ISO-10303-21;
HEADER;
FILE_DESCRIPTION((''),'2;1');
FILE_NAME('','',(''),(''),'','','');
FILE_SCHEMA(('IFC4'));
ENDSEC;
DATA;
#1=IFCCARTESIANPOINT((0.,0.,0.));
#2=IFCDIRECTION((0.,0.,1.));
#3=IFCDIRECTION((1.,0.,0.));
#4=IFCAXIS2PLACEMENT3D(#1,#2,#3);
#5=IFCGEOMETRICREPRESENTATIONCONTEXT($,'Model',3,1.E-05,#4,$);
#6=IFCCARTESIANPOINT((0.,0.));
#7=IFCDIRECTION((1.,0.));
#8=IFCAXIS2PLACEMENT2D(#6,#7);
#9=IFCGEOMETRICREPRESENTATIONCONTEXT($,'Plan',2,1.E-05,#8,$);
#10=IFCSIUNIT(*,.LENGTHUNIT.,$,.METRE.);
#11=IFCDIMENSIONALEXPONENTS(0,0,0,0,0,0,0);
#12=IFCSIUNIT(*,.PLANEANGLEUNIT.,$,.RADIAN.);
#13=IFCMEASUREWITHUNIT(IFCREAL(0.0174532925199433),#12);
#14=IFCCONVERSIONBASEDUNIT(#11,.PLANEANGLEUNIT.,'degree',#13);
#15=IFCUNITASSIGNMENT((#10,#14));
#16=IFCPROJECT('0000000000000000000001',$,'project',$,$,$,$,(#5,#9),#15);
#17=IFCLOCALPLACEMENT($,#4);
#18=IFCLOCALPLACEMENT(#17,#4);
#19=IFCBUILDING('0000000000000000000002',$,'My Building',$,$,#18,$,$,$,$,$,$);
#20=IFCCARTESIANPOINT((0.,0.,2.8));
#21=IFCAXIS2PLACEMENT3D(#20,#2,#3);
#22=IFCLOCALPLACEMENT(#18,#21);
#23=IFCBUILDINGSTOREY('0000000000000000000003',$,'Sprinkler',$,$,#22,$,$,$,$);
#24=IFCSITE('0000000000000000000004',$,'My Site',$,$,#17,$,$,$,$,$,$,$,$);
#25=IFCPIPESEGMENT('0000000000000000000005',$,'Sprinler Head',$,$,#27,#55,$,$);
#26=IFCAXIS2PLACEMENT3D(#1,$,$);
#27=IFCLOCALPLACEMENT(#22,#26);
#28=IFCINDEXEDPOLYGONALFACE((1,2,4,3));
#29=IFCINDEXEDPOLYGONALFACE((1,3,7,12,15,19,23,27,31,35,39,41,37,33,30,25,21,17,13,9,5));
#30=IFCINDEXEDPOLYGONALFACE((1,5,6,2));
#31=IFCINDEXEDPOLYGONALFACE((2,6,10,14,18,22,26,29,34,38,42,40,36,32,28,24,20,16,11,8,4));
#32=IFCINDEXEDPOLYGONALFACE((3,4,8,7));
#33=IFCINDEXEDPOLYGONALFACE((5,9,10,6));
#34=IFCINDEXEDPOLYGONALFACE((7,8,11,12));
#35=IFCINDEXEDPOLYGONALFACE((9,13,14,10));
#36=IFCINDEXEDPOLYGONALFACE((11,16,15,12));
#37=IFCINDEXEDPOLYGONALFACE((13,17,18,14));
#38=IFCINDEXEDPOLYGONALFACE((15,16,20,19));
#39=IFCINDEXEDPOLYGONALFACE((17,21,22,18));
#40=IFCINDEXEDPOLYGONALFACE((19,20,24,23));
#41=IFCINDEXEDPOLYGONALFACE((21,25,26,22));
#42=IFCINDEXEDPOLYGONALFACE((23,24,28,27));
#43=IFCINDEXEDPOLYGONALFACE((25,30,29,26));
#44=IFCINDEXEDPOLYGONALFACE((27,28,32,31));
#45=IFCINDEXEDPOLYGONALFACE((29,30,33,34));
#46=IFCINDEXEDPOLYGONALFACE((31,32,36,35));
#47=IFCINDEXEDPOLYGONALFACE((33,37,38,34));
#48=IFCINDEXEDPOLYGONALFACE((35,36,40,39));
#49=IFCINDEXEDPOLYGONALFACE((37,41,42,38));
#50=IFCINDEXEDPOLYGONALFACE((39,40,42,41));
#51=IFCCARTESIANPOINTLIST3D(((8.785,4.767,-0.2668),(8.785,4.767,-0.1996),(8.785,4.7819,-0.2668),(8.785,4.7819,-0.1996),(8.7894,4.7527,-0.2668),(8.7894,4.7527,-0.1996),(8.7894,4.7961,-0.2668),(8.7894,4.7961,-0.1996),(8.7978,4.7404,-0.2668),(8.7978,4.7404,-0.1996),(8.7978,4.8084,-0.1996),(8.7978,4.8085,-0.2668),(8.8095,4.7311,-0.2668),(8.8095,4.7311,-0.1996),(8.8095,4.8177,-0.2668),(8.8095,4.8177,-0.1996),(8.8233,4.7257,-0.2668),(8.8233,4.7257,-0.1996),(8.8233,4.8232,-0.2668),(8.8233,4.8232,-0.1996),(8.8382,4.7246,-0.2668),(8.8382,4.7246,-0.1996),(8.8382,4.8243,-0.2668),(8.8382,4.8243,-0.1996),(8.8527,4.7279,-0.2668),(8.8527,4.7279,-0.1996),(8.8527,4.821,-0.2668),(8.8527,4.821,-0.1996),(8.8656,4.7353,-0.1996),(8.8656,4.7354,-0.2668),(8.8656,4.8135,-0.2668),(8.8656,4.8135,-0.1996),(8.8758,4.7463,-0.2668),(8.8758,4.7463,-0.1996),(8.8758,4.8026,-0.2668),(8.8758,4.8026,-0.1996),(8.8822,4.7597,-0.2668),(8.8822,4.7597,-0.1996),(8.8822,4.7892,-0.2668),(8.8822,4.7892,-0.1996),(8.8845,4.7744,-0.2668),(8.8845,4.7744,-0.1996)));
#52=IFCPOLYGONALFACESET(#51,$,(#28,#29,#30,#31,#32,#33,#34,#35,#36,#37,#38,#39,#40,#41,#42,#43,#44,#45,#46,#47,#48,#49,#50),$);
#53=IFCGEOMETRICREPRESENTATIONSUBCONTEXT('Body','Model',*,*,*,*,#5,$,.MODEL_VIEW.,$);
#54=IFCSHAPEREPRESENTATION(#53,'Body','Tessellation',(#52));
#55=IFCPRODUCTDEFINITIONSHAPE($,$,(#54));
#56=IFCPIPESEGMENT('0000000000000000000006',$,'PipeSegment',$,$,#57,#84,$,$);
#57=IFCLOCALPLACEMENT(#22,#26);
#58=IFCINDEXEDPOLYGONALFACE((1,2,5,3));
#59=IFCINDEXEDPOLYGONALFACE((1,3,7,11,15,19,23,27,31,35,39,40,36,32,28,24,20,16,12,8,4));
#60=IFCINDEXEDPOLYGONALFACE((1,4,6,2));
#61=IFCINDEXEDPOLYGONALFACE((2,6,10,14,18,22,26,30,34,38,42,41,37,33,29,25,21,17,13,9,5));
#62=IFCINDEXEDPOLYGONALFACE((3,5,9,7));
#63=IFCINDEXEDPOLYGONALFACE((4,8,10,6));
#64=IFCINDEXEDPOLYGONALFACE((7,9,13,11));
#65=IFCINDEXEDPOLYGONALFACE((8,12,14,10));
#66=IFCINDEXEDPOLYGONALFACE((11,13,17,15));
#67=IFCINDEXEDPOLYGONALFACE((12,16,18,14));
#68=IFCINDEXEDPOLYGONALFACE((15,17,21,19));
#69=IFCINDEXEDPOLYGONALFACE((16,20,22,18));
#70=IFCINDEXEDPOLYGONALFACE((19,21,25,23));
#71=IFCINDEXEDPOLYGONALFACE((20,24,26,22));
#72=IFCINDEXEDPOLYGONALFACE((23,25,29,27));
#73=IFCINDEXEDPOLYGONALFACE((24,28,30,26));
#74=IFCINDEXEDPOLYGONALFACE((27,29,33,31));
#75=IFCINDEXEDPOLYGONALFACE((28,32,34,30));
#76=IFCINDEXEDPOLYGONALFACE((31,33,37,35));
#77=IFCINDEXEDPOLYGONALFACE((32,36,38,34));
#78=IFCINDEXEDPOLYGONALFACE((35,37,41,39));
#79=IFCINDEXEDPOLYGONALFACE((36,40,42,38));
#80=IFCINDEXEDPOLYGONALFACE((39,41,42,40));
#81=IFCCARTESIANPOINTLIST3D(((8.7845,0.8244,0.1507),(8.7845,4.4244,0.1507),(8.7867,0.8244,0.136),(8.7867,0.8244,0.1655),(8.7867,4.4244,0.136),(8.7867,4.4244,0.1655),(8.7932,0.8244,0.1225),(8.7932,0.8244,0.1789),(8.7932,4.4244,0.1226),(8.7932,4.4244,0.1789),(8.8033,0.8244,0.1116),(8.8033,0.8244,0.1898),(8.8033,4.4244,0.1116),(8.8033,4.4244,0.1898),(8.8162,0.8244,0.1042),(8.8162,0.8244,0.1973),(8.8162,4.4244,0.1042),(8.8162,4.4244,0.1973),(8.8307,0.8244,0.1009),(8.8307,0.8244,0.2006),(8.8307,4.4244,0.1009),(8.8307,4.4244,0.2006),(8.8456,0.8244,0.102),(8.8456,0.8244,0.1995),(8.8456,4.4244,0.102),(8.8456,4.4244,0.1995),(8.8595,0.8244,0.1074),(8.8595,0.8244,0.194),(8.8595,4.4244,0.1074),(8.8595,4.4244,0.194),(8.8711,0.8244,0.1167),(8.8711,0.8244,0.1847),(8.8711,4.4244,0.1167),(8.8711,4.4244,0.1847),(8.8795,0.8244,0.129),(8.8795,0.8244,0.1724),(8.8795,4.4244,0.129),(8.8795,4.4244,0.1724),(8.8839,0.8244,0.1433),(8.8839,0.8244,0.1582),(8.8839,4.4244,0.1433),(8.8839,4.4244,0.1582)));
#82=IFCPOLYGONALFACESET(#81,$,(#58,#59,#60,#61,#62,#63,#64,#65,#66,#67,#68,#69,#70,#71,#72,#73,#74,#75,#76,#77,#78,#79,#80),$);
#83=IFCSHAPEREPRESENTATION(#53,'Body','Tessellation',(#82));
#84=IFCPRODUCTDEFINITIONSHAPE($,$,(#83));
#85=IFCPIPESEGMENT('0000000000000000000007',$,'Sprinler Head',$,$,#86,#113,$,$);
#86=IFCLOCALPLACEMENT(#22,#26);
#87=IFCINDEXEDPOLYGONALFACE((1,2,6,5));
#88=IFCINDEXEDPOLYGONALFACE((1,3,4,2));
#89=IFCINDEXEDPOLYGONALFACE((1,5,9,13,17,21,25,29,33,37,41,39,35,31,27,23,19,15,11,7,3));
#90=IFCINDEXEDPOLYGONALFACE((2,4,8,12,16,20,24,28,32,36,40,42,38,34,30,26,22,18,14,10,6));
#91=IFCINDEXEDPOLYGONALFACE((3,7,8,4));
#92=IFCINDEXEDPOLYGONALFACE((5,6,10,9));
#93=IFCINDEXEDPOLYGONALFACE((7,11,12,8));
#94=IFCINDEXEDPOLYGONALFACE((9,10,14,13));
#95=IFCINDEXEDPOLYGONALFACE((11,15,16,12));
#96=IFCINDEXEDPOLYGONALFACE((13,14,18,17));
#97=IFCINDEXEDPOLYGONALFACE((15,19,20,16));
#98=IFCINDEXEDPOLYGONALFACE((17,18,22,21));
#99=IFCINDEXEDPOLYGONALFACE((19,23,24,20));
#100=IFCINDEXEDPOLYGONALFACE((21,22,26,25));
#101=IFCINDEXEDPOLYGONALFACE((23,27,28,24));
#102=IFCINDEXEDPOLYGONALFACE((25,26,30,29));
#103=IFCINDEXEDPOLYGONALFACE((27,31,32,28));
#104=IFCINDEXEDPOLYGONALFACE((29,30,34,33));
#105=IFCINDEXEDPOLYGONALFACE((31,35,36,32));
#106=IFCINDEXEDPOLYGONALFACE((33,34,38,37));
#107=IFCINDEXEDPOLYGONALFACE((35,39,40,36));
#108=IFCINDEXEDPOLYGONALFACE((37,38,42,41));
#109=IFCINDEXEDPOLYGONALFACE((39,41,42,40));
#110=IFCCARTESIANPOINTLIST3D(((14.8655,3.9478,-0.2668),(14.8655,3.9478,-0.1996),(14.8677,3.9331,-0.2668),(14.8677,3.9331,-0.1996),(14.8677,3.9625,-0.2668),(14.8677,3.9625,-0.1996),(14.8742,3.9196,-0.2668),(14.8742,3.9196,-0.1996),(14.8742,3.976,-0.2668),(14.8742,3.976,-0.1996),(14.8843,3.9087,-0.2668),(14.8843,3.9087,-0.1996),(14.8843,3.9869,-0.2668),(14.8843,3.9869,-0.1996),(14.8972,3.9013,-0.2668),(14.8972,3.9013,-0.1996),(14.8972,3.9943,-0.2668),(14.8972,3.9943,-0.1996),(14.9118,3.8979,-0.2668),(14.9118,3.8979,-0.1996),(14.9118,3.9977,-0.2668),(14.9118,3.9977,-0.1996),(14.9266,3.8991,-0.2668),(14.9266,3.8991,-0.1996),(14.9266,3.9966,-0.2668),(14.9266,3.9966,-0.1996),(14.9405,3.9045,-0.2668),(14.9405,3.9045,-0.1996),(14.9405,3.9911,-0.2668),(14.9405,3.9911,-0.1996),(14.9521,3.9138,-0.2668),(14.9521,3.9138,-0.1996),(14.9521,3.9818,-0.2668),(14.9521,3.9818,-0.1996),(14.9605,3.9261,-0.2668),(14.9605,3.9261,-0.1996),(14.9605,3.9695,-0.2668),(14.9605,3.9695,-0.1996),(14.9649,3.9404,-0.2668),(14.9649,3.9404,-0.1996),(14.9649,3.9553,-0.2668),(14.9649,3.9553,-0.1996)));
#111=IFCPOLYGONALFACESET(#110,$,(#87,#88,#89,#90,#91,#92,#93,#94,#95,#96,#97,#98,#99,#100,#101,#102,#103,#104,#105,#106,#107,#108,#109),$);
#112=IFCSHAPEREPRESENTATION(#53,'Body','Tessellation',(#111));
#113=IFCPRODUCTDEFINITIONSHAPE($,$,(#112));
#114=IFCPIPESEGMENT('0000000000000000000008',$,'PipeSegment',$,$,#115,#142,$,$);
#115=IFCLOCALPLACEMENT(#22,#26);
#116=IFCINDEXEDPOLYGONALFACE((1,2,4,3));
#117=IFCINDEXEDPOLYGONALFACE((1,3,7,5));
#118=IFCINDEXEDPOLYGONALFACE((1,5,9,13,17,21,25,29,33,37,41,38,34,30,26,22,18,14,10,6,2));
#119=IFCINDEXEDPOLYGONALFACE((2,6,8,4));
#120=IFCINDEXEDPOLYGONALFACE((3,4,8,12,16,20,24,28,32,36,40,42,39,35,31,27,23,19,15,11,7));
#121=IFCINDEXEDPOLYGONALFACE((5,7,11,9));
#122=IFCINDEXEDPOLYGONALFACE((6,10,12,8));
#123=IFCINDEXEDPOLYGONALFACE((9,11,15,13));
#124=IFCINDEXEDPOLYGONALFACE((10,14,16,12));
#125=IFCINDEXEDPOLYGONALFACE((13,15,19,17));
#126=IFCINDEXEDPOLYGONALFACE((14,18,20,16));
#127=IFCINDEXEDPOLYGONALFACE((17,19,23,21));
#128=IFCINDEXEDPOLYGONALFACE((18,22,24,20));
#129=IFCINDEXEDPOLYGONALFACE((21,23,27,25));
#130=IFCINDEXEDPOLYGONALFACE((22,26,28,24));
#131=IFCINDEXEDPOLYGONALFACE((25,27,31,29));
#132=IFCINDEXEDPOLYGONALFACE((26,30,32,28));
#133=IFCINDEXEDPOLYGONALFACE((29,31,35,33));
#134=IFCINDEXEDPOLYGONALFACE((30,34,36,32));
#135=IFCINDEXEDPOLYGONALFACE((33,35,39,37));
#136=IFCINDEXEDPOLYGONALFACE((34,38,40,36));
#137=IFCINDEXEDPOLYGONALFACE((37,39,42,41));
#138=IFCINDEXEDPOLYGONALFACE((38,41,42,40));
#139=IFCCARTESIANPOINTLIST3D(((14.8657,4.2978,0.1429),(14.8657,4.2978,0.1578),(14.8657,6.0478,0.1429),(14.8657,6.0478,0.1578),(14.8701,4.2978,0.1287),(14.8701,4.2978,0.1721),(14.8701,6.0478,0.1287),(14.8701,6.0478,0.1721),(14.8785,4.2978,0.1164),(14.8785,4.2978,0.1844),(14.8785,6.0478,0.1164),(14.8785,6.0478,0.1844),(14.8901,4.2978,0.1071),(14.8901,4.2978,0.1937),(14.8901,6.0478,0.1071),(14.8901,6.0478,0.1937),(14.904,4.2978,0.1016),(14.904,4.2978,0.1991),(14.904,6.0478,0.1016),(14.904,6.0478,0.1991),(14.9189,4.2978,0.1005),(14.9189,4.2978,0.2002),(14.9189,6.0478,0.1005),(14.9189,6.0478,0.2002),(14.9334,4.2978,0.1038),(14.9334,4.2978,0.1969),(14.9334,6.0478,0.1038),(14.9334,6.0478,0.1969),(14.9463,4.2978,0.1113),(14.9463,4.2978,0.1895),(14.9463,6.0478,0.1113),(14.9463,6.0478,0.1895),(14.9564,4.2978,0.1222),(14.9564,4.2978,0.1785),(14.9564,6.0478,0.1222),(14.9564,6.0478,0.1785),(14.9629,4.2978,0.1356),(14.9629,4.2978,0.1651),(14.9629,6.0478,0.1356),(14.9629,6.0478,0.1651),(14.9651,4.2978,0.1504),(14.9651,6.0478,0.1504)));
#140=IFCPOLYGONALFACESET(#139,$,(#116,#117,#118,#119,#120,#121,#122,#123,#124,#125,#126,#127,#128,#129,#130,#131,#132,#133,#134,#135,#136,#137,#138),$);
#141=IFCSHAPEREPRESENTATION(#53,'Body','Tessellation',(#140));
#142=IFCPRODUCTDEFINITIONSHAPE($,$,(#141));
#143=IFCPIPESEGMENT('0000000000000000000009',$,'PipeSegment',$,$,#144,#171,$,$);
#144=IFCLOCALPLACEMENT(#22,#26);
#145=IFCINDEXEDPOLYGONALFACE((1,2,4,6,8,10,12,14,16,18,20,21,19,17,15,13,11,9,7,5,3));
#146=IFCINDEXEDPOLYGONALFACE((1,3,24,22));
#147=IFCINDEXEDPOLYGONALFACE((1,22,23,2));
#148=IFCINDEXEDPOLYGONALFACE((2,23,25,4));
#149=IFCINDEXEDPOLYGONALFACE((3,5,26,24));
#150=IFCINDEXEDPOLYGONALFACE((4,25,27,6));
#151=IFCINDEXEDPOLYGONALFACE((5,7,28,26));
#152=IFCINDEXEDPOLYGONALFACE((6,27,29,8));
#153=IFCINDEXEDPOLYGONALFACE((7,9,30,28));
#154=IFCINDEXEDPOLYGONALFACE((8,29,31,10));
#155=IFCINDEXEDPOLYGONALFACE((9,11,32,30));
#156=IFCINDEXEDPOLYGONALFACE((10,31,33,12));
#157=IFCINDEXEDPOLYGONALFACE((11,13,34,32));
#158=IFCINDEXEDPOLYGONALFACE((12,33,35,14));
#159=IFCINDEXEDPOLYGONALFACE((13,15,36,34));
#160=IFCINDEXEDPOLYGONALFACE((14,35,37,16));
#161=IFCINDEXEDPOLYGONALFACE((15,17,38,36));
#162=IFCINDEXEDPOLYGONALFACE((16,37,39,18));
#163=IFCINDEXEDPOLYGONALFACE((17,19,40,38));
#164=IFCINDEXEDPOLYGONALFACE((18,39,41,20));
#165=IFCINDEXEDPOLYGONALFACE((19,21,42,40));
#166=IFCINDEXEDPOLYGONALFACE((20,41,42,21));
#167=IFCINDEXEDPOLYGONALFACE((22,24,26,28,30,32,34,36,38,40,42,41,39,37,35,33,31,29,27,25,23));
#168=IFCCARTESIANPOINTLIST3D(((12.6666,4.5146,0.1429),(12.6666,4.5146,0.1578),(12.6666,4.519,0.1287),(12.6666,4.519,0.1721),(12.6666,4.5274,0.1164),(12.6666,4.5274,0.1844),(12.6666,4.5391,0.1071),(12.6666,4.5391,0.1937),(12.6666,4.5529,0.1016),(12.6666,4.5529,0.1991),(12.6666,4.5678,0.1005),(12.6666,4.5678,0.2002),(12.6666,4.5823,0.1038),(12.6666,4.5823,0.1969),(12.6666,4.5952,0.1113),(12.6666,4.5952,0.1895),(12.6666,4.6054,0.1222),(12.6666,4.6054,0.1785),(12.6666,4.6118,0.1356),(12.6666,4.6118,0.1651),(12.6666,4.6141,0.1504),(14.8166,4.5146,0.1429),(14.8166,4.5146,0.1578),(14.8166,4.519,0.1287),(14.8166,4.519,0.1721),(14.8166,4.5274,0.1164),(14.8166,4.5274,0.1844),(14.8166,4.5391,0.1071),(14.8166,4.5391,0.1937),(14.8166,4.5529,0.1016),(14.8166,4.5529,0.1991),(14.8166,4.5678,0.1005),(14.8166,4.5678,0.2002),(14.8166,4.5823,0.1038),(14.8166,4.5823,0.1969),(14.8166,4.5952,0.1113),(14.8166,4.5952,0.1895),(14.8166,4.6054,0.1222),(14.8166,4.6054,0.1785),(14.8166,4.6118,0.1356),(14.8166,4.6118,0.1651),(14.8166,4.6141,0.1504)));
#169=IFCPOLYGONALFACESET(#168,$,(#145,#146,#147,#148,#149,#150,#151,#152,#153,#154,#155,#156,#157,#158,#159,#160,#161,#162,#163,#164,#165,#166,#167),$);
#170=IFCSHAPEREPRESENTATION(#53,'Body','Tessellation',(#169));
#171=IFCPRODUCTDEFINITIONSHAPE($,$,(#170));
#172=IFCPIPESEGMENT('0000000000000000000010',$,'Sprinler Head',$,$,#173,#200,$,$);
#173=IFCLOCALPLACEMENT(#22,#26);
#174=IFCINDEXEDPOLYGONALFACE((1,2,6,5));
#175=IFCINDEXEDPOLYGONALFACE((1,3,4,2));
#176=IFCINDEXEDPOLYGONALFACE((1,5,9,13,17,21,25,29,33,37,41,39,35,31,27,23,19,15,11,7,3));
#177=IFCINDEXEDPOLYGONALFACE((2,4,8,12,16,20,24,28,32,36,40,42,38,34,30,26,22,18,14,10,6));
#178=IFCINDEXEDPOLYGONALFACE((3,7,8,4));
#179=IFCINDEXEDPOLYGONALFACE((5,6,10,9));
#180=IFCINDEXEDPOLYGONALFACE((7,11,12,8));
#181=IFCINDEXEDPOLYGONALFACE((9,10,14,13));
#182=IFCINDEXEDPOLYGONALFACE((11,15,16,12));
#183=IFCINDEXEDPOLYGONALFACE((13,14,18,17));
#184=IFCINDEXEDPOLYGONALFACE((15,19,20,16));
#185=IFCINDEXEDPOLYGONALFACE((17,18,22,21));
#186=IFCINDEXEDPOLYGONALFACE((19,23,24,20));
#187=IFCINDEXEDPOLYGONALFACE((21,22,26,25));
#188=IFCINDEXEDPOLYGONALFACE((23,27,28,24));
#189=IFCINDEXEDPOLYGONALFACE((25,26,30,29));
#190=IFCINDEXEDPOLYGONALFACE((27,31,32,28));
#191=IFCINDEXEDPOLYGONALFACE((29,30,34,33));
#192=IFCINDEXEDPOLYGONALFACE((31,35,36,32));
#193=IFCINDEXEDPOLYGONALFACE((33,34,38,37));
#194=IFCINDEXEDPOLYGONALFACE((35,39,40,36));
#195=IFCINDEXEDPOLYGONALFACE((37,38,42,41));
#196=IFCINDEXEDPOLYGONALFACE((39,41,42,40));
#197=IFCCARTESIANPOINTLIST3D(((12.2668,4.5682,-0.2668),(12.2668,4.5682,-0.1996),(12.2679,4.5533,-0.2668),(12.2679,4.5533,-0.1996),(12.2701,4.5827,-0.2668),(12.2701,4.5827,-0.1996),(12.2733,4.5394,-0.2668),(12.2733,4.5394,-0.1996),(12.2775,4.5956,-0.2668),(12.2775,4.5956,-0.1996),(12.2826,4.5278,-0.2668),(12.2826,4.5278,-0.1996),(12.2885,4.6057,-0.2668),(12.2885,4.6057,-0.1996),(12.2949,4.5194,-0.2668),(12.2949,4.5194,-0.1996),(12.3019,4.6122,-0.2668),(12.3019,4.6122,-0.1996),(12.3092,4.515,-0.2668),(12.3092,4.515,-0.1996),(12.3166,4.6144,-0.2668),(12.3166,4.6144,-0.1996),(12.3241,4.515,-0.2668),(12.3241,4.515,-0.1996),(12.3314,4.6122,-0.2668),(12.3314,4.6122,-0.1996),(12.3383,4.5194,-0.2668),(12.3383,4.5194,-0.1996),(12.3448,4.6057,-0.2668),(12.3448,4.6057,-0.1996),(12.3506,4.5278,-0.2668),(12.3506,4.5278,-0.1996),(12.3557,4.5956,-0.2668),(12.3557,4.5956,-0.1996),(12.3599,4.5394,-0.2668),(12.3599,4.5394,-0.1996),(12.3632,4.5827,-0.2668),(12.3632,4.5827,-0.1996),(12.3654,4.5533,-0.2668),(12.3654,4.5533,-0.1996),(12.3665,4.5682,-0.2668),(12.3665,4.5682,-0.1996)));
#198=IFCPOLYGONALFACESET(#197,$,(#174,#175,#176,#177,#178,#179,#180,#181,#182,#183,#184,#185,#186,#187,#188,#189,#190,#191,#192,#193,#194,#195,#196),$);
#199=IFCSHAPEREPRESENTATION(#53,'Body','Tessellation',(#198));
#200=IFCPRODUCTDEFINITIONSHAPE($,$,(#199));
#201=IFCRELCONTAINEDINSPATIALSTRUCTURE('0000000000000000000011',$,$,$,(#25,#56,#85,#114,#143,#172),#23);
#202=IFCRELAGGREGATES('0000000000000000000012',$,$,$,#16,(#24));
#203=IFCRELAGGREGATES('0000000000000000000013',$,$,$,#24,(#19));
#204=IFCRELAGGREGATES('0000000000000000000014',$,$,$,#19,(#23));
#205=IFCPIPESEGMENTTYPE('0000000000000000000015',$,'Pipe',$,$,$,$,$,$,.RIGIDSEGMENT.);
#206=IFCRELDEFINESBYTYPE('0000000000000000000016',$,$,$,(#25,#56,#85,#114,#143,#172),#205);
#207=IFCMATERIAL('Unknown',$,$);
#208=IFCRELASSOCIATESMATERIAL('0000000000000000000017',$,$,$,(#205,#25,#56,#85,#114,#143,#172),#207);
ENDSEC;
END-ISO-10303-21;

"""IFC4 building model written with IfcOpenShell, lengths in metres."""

from ifc_helpers import new_model, entity, si_unit, converted_unit, frame, origin_with_axes, origin_2d_with_axis, place, context, subcontext, project, spatial, circle, extrude, material, material_profile, profile_set, profile_usage, type_object, element, save


model = new_model("IFC4")

# Units and contexts
model_context = context("Model", 3, precision=1e-05, world=origin_with_axes())
plan_context = context("Plan", 2, precision=1e-05, world=origin_2d_with_axis())
body_context = subcontext(model_context, "Body", "Model", "MODEL_VIEW")
ifc_project = project(units=[si_unit("LENGTHUNIT", "METRE"), converted_unit("PLANEANGLEUNIT", "degree", entity("IfcReal", 0.0174532925199433), si_unit("PLANEANGLEUNIT", "RADIAN"), dimensions=[0, 0, 0, 0, 0, 0, 0])], contexts=[model_context, plan_context])

# Site, building, storey
site_placement = place(None, origin_with_axes())
site = spatial("IfcSite", under=ifc_project, at=site_placement, Name="My Site")
building_placement = place(site_placement, origin_with_axes())
building = spatial("IfcBuilding", under=site, at=building_placement, Name="My Building")
storey_placement = place(building_placement, frame((0.0, 0.0, 2.8), z_axis=(0.0, 0.0, 1.0), x_axis=(1.0, 0.0, 0.0)))
storey = spatial("IfcBuildingStorey", under=building, at=storey_placement, Name="Sprinkler")

# Pipe segments
ifc_material = material(Name="Unknown")
ifc_material_profile_1 = material_profile(ifc_material, circle(Radius=0.05))
ifc_profile_set_1 = profile_set([ifc_material_profile_1])
pipe_segment_type = type_object("IfcPipeSegmentType", Name="Pipe", PredefinedType="RIGIDSEGMENT", material=ifc_profile_set_1)
ifc_profile_usage_1 = profile_usage(ifc_profile_set_1, cardinal=5)
pipe_segment_1_placement = place(storey_placement, frame((8.8345, 4.7744, -0.2668), z_axis=(0.0, -0.000008, 1.0), x_axis=(1.0, 0.0, 0.0)))
element("IfcPipeSegment", 1, at=pipe_segment_1_placement, inside=storey, type_object=pipe_segment_type, material=ifc_profile_usage_1, Name="Sprinler Head", context=body_context, shape_type="SweptSolid", body=[
    extrude(circle(Radius=0.05), origin_with_axes(), (0.0, 0.0, 1.0), 0.0672),
])
ifc_profile_usage_2 = profile_usage(ifc_profile_set_1, cardinal=5)
pipe_segment_2_placement = place(storey_placement, frame((8.8345, 0.8244, 0.1507), z_axis=(0.0, 1.0, 0.000004), x_axis=(-1.0, 0.0, 0.0)))
element("IfcPipeSegment", 2, at=pipe_segment_2_placement, inside=storey, type_object=pipe_segment_type, material=ifc_profile_usage_2, Name="PipeSegment", context=body_context, shape_type="SweptSolid", body=[
    extrude(circle(Radius=0.05), origin_with_axes(), (0.0, 0.0, 1.0), 3.6),
])
ifc_profile_usage_3 = profile_usage(ifc_profile_set_1, cardinal=5)
pipe_segment_3_placement = place(storey_placement, frame((14.9155, 3.9478, -0.2668), z_axis=(0.0, 0.000008, 1.0), x_axis=(-1.0, 0.0, 0.0)))
element("IfcPipeSegment", 3, at=pipe_segment_3_placement, inside=storey, type_object=pipe_segment_type, material=ifc_profile_usage_3, Name="Sprinler Head", context=body_context, shape_type="SweptSolid", body=[
    extrude(circle(Radius=0.05), origin_with_axes(), (0.0, 0.0, 1.0), 0.0672),
])
ifc_profile_usage_4 = profile_usage(ifc_profile_set_1, cardinal=5)
pipe_segment_4_placement = place(storey_placement, frame((14.9151, 6.0478, 0.1504), z_axis=(0.0, -1.0, 0.0), x_axis=(1.0, 0.0, 0.0)))
element("IfcPipeSegment", 4, at=pipe_segment_4_placement, inside=storey, type_object=pipe_segment_type, material=ifc_profile_usage_4, Name="PipeSegment", context=body_context, shape_type="SweptSolid", body=[
    extrude(circle(Radius=0.05), origin_with_axes(), (0.0, 0.0, 1.0), 1.75),
])
ifc_profile_usage_5 = profile_usage(ifc_profile_set_1, cardinal=5)
pipe_segment_5_placement = place(storey_placement, frame((12.6666, 4.5641, 0.1504), z_axis=(1.0, 0.0, 0.0), x_axis=(0.0, 1.0, 0.0)))
element("IfcPipeSegment", 5, at=pipe_segment_5_placement, inside=storey, type_object=pipe_segment_type, material=ifc_profile_usage_5, Name="PipeSegment", context=body_context, shape_type="SweptSolid", body=[
    extrude(circle(Radius=0.05), origin_with_axes(), (0.0, 0.0, 1.0), 2.15),
])
ifc_profile_usage_6 = profile_usage(ifc_profile_set_1, cardinal=5)
pipe_segment_6_placement = place(storey_placement, frame((12.3166, 4.5644, -0.2668), z_axis=(0.000008, 0.0, 1.0), x_axis=(0.0, 1.0, 0.0)))
element("IfcPipeSegment", 6, at=pipe_segment_6_placement, inside=storey, type_object=pipe_segment_type, material=ifc_profile_usage_6, Name="Sprinler Head", context=body_context, shape_type="SweptSolid", body=[
    extrude(circle(Radius=0.05), origin_with_axes(), (0.0, 0.0, 1.0), 0.0672),
])

save(model, "model.ifc")
